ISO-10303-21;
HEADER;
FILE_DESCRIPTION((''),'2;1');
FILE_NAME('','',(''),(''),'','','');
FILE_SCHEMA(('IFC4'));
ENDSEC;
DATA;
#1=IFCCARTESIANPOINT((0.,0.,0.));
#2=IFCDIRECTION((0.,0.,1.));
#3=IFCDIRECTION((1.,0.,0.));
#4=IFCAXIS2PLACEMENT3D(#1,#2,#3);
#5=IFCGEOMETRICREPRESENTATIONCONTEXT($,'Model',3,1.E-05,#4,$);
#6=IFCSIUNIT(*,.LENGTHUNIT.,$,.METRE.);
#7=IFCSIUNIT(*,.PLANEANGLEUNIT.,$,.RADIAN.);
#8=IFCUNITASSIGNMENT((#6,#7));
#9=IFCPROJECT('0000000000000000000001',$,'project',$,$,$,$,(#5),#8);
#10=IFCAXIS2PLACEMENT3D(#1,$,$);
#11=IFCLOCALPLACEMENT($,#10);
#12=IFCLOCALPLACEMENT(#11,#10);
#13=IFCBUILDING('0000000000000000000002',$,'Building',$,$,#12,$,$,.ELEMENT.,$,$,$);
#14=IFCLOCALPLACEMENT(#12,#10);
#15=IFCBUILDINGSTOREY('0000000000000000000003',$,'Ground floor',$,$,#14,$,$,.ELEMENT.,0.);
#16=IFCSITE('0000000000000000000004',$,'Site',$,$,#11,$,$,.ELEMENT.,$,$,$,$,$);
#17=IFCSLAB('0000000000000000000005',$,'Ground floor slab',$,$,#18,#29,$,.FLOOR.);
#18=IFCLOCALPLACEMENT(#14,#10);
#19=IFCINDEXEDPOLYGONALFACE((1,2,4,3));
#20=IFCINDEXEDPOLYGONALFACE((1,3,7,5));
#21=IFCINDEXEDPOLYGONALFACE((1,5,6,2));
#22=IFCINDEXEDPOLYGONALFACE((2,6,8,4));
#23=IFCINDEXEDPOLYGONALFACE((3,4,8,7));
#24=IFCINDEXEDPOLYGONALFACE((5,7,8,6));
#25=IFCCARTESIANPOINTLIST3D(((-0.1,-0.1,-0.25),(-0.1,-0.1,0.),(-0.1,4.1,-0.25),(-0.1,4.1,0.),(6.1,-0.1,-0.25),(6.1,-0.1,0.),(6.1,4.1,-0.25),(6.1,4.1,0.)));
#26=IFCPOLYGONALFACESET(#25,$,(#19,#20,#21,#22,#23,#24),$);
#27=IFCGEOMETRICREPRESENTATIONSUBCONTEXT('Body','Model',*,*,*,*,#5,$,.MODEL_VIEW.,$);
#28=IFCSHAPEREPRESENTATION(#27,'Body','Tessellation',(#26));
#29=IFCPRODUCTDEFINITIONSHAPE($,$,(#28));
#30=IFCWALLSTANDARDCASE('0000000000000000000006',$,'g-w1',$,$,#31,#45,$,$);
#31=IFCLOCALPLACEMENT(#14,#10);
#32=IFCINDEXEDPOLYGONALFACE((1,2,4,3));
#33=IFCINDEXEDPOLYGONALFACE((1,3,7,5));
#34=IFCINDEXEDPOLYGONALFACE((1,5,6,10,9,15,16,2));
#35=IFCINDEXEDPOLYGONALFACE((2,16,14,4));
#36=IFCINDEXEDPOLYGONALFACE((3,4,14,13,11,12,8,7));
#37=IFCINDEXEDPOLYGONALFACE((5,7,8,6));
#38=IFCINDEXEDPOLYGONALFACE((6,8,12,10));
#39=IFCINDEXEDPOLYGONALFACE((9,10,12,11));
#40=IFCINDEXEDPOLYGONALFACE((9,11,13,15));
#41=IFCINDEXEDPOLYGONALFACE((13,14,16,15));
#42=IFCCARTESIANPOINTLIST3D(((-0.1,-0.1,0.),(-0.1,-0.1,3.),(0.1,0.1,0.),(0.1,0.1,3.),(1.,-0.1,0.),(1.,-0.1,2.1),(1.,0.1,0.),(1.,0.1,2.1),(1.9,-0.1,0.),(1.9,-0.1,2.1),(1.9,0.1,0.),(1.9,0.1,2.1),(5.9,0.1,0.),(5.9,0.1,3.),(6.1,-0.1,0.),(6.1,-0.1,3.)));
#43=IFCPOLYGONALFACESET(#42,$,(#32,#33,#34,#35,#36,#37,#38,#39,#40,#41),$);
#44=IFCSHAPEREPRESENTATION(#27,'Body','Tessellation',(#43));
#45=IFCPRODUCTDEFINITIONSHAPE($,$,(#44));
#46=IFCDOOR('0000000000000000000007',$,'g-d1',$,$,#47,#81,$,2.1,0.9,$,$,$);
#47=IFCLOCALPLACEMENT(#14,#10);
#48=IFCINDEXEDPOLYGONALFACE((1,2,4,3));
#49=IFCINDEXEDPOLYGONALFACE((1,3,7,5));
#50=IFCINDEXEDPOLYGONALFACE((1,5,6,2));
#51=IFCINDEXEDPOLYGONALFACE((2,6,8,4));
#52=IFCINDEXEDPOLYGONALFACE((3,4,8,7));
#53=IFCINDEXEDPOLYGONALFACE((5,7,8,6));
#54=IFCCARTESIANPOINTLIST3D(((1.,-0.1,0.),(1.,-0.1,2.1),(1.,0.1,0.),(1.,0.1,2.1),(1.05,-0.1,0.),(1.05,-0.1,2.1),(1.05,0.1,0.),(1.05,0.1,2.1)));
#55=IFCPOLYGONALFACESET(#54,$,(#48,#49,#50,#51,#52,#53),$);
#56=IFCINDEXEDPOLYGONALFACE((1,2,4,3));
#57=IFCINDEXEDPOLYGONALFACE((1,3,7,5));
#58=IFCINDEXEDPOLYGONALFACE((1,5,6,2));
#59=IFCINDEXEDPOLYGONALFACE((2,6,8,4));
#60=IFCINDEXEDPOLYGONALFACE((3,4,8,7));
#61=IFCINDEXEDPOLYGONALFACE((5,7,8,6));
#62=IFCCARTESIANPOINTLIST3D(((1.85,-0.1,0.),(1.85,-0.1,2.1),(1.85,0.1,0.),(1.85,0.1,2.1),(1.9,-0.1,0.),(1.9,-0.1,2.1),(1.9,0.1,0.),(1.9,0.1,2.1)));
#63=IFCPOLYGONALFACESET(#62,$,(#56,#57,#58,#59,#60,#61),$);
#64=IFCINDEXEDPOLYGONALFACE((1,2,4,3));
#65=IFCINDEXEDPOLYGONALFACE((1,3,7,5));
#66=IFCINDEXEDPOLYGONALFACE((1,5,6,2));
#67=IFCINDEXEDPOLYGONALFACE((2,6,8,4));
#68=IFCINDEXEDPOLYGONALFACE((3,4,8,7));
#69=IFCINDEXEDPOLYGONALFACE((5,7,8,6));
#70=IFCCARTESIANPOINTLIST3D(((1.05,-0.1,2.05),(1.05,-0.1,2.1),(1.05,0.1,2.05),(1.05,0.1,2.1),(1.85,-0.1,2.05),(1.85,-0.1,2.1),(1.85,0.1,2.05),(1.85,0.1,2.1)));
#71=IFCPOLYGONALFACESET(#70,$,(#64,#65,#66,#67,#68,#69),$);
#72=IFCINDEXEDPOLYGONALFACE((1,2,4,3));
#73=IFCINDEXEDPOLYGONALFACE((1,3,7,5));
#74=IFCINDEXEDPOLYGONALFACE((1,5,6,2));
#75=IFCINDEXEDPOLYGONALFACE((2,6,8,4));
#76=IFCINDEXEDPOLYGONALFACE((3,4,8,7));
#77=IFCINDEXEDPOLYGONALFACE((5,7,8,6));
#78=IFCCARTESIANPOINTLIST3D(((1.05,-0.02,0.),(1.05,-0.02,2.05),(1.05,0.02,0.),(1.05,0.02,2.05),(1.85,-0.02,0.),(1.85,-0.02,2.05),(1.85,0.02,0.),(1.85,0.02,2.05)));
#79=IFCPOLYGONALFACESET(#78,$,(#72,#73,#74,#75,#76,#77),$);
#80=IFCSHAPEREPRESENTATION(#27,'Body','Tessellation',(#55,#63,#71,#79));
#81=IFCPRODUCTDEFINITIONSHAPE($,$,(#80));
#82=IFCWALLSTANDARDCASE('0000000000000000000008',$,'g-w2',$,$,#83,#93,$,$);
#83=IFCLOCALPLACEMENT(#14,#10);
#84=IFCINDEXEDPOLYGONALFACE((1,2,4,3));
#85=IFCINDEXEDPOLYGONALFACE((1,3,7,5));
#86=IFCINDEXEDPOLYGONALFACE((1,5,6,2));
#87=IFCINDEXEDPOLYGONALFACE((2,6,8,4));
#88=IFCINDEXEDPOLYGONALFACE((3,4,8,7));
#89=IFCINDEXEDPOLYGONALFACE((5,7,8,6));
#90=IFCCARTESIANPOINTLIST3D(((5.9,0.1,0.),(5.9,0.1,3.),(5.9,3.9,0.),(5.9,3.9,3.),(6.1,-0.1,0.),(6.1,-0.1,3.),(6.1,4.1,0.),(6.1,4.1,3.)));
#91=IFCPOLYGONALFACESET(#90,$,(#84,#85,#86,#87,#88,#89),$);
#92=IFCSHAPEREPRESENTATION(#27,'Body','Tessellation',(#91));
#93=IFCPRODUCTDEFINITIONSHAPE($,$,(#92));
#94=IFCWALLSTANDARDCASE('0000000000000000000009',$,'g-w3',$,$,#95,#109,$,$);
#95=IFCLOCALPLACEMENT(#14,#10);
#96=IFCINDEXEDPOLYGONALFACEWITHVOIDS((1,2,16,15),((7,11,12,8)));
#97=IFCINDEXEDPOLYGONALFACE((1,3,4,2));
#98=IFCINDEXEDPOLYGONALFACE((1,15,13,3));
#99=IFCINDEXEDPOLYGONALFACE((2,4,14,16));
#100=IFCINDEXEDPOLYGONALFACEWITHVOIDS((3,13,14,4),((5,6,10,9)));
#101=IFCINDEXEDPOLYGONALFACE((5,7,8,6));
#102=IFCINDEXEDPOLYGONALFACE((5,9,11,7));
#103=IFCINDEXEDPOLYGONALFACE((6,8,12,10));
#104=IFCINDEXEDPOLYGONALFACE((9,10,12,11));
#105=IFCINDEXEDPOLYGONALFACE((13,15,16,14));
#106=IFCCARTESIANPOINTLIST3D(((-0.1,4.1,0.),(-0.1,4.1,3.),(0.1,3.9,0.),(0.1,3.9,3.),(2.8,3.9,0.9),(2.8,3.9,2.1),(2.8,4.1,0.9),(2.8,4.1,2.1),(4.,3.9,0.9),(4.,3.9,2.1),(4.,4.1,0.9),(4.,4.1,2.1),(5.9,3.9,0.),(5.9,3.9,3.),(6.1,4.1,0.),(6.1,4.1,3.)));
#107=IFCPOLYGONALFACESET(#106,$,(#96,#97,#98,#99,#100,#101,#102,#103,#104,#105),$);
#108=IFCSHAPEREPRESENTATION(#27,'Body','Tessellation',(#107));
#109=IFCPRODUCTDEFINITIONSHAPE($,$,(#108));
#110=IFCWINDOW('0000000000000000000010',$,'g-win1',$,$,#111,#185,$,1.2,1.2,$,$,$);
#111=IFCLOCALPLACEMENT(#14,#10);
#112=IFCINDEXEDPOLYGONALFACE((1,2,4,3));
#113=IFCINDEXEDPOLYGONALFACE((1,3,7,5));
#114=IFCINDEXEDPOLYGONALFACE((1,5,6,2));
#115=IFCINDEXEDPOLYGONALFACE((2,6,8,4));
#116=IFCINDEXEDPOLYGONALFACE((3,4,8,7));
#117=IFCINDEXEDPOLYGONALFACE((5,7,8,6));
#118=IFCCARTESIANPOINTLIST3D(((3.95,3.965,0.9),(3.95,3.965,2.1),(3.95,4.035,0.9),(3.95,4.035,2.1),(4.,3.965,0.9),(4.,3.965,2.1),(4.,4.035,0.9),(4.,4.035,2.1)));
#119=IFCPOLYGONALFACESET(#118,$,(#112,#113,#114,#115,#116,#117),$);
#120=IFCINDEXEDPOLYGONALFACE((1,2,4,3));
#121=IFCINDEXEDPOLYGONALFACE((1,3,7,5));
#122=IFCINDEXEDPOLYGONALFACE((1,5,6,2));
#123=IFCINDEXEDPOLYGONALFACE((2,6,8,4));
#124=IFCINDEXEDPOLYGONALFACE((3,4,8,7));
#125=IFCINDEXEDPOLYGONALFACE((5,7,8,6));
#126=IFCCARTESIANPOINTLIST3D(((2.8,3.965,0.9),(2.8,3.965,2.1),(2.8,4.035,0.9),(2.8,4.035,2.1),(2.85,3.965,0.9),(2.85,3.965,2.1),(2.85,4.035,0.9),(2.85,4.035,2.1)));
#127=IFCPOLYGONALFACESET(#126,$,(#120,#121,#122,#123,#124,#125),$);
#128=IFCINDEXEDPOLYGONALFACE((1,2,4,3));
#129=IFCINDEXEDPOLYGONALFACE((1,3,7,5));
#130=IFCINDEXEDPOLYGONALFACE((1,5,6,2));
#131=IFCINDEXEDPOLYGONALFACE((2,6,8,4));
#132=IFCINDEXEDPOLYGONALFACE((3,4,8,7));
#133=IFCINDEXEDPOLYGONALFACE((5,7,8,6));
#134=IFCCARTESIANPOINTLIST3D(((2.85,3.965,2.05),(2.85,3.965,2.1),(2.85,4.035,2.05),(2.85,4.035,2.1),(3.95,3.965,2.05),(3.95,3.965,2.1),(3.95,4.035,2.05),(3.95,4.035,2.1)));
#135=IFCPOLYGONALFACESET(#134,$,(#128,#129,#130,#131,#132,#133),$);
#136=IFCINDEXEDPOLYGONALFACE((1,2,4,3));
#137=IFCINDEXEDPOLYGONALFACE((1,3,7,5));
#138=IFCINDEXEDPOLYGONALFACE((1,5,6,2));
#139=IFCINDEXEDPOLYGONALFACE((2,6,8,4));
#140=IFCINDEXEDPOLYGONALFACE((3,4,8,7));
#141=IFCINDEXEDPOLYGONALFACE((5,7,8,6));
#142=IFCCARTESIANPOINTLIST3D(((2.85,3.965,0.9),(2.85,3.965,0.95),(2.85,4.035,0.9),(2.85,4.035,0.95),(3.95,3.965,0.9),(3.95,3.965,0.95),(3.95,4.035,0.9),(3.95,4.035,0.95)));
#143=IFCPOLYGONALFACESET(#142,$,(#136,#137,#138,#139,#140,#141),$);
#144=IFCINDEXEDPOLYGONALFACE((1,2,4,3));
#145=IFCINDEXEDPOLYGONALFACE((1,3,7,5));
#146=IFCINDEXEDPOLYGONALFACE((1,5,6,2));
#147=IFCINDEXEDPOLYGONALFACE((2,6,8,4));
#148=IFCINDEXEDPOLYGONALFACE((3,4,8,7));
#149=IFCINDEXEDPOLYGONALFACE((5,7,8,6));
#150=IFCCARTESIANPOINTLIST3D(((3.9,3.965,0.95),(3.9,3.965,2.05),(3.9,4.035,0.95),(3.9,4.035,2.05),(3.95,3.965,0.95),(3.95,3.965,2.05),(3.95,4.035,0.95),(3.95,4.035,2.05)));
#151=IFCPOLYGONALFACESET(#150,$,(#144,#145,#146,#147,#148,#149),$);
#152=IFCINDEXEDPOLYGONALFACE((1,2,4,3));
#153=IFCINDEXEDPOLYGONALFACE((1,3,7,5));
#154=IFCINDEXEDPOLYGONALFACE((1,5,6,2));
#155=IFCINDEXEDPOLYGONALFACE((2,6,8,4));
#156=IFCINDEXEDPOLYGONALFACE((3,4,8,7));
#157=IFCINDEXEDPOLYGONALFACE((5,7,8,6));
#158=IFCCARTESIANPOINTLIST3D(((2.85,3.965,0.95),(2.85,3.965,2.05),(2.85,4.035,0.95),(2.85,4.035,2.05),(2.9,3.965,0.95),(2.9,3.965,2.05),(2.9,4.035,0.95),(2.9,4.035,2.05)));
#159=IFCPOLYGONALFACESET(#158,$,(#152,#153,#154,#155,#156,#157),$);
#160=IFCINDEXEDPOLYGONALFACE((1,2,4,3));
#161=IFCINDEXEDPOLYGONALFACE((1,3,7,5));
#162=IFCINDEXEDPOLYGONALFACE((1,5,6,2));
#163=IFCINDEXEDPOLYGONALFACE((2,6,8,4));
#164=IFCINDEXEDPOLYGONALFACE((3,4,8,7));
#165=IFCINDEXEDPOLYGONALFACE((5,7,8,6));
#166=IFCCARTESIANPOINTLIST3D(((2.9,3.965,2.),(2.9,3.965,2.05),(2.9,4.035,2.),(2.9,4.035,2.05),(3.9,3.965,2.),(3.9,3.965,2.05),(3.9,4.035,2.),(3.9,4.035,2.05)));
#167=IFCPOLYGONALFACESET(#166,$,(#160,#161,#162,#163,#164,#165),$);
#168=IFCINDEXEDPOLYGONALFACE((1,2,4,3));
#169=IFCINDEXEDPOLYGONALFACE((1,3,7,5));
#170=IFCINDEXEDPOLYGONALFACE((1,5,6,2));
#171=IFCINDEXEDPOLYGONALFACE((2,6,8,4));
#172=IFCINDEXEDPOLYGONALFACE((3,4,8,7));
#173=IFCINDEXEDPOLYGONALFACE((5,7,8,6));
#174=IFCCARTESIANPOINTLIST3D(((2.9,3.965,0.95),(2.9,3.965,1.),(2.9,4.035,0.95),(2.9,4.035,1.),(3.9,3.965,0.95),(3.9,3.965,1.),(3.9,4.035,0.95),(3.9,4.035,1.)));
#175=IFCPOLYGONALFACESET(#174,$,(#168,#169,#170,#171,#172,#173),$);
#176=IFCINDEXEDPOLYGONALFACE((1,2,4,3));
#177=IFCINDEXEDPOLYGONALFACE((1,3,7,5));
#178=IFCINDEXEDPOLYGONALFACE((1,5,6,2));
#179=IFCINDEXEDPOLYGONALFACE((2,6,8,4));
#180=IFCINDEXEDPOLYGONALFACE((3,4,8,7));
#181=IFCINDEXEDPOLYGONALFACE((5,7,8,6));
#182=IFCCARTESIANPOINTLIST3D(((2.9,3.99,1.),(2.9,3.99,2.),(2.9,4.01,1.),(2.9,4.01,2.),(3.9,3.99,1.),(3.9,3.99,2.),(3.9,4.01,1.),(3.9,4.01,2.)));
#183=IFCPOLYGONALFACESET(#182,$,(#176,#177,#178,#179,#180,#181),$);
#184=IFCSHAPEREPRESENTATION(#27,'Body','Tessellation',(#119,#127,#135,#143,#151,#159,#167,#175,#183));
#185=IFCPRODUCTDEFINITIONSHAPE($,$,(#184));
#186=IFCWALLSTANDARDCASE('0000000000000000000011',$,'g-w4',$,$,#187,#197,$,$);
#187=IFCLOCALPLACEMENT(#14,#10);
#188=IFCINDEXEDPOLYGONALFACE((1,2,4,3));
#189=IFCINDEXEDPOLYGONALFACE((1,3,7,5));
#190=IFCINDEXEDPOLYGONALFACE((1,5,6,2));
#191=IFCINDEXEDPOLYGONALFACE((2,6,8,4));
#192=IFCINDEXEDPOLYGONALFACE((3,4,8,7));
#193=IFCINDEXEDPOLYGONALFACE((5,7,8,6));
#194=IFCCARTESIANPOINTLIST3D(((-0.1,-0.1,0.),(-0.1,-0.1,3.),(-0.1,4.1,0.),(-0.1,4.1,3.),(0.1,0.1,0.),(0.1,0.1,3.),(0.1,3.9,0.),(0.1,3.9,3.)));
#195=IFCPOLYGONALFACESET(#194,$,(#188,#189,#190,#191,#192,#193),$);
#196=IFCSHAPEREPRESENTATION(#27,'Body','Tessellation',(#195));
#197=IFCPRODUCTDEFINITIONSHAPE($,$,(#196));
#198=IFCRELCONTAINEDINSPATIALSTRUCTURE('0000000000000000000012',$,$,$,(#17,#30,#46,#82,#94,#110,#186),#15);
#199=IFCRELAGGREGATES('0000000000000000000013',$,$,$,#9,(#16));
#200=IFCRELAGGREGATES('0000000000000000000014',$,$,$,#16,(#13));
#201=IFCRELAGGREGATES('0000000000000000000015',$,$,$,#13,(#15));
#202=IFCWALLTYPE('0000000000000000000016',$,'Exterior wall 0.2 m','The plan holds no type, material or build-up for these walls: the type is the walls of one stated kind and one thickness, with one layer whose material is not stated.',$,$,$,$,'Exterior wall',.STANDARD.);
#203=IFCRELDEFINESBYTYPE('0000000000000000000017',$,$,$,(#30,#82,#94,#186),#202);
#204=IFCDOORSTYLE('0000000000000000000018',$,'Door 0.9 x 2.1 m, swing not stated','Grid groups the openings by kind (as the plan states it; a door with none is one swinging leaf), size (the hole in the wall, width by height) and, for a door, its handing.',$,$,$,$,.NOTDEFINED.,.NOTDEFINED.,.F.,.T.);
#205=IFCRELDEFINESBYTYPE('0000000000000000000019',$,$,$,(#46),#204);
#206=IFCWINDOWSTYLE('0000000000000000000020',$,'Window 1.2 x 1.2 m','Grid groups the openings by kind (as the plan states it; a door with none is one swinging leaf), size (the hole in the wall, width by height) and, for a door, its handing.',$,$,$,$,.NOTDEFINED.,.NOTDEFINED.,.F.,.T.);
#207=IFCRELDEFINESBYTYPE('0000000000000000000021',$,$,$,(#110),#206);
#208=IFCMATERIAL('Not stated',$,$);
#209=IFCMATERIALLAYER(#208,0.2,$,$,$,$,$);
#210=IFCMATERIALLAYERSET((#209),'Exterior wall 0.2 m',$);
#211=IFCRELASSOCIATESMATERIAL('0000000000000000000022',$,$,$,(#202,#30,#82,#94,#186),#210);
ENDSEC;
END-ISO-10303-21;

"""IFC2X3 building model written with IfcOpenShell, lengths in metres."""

from ifc_helpers import new_model, si_unit, frame, frame_2d, origin, origin_with_axes, place, context, subcontext, project, spatial, polyline, rectangle, outline, extrude, material, layer, layer_set, layer_usage, type_object, element, fill, save


model = new_model("IFC2X3")

# Units and contexts
model_context = context("Model", 3, precision=1e-05, world=origin_with_axes())
body_context = subcontext(model_context, "Body", "Model", "MODEL_VIEW")
ifc_project = project(units=[si_unit("LENGTHUNIT", "METRE"), si_unit("PLANEANGLEUNIT", "RADIAN")], contexts=[model_context])

# Site, building, storey
site_placement = place(None, origin())
site = spatial("IfcSite", under=ifc_project, at=site_placement, Name="Site", CompositionType="ELEMENT")
building_placement = place(site_placement, origin())
building = spatial("IfcBuilding", under=site, at=building_placement, Name="Building", CompositionType="ELEMENT")
storey_placement = place(building_placement, origin())
storey = spatial("IfcBuildingStorey", under=building, at=storey_placement, Name="Ground floor", CompositionType="ELEMENT", Elevation=0.0)

# Slab
slab_placement = place(storey_placement, frame((0.0, 0.0, -0.25)))
element("IfcSlab", 1, at=slab_placement, inside=storey, Name="Ground floor slab", PredefinedType="FLOOR", context=body_context, shape_type="SweptSolid", body=[
    extrude(outline(polyline([(-0.1, -0.1), (6.1, -0.1), (6.1, 4.1), (-0.1, 4.1), (-0.1, -0.1)])), origin(), (0.0, 0.0, 1.0), 0.25),
])

# Wall, opening, door
ifc_material = material(Name="Not stated")
ifc_layer = layer(ifc_material, 0.2)
ifc_layer_set = layer_set([ifc_layer], Name="Exterior wall 0.2 m")
ifc_layer_usage = layer_usage(ifc_layer_set, "AXIS2", "POSITIVE", -0.1)
wall_type = type_object("IfcWallType", Name="Exterior wall 0.2 m", Description="The plan holds no type, material or build-up for these walls: the type is the walls of one stated kind and one thickness, with one layer whose material is not stated.", ElementType="Exterior wall", PredefinedType="STANDARD", material=ifc_layer_set)
wall_1_placement = place(storey_placement, origin_with_axes())
wall_1 = element("IfcWallStandardCase", 2, at=wall_1_placement, inside=storey, type_object=wall_type, material=ifc_layer_usage, Name="g-w1", context=body_context, shape_type="SweptSolid", body=[
    extrude(outline(polyline([(-0.1, -0.1), (6.1, -0.1), (5.9, 0.1), (0.1, 0.1), (-0.1, -0.1)])), origin(), (0.0, 0.0, 1.0), 3.0),
])
opening_1_placement = place(wall_1_placement, frame((1.0, 0.0, 0.0)))
opening_1 = element("IfcOpeningElement", 3, at=opening_1_placement, cuts=wall_1, context=body_context, shape_type="SweptSolid", body=[
    extrude(rectangle(XDim=0.9, YDim=0.22, at=frame_2d((0.45, 0.0), x_axis=(1.0, 0.0))), origin(), (0.0, 0.0, 1.0), 2.1),
])
door_style = type_object("IfcDoorStyle", Name="Door 0.9 x 2.1 m, swing not stated", Description="Grid groups the openings by kind (as the plan states it; a door with none is one swinging leaf), size (the hole in the wall, width by height) and, for a door, its handing.", ConstructionType="NOTDEFINED", OperationType="NOTDEFINED", ParameterTakesPrecedence=False, Sizeable=True)
door_placement = place(opening_1_placement, origin())
door = element("IfcDoor", 4, at=door_placement, inside=storey, type_object=door_style, Name="g-d1", OverallHeight=2.1, OverallWidth=0.9, context=body_context, shape_type="SweptSolid", body=[
    extrude(rectangle(XDim=0.05, YDim=0.2, at=frame_2d((0.025, 0.0), x_axis=(1.0, 0.0))), origin(), (0.0, 0.0, 1.0), 2.1),
    extrude(rectangle(XDim=0.05, YDim=0.2, at=frame_2d((0.875, 0.0), x_axis=(1.0, 0.0))), origin(), (0.0, 0.0, 1.0), 2.1),
    extrude(rectangle(XDim=0.8, YDim=0.2, at=frame_2d((0.45, 0.0), x_axis=(1.0, 0.0))), frame((0.0, 0.0, 2.05)), (0.0, 0.0, 1.0), 0.05),
    extrude(rectangle(XDim=0.8, YDim=0.04, at=frame_2d((0.45, 0.0), x_axis=(1.0, 0.0))), origin(), (0.0, 0.0, 1.0), 2.05),
])
fill(opening_1, door)

# Wall
wall_2_placement = place(storey_placement, frame((6.0, 0.0, 0.0), z_axis=(0.0, 0.0, 1.0), x_axis=(0.0, 1.0, 0.0)))
element("IfcWallStandardCase", 5, at=wall_2_placement, inside=storey, type_object=wall_type, material=ifc_layer_usage, Name="g-w2", context=body_context, shape_type="SweptSolid", body=[
    extrude(outline(polyline([(-0.1, -0.1), (4.1, -0.1), (3.9, 0.1), (0.1, 0.1), (-0.1, -0.1)])), origin(), (0.0, 0.0, 1.0), 3.0),
])

# Wall, opening, window
wall_3_placement = place(storey_placement, frame((6.0, 4.0, 0.0), z_axis=(0.0, 0.0, 1.0), x_axis=(-1.0, 0.0, 0.0)))
wall_3 = element("IfcWallStandardCase", 6, at=wall_3_placement, inside=storey, type_object=wall_type, material=ifc_layer_usage, Name="g-w3", context=body_context, shape_type="SweptSolid", body=[
    extrude(outline(polyline([(-0.1, -0.1), (6.1, -0.1), (5.9, 0.1), (0.1, 0.1), (-0.1, -0.1)])), origin(), (0.0, 0.0, 1.0), 3.0),
])
opening_2_placement = place(wall_3_placement, frame((2.0, 0.0, 0.9)))
opening_2 = element("IfcOpeningElement", 7, at=opening_2_placement, cuts=wall_3, context=body_context, shape_type="SweptSolid", body=[
    extrude(rectangle(XDim=1.2, YDim=0.22, at=frame_2d((0.6, 0.0), x_axis=(1.0, 0.0))), origin(), (0.0, 0.0, 1.0), 1.2),
])
window_style = type_object("IfcWindowStyle", Name="Window 1.2 x 1.2 m", Description="Grid groups the openings by kind (as the plan states it; a door with none is one swinging leaf), size (the hole in the wall, width by height) and, for a door, its handing.", ConstructionType="NOTDEFINED", OperationType="NOTDEFINED", ParameterTakesPrecedence=False, Sizeable=True)
window_placement = place(opening_2_placement, origin())
window = element("IfcWindow", 8, at=window_placement, inside=storey, type_object=window_style, Name="g-win1", OverallHeight=1.2, OverallWidth=1.2, context=body_context, shape_type="SweptSolid", body=[
    extrude(rectangle(XDim=0.05, YDim=0.07, at=frame_2d((0.025, 0.0), x_axis=(1.0, 0.0))), origin(), (0.0, 0.0, 1.0), 1.2),
    extrude(rectangle(XDim=0.05, YDim=0.07, at=frame_2d((1.175, 0.0), x_axis=(1.0, 0.0))), origin(), (0.0, 0.0, 1.0), 1.2),
    extrude(rectangle(XDim=1.1, YDim=0.07, at=frame_2d((0.6, 0.0), x_axis=(1.0, 0.0))), frame((0.0, 0.0, 1.15)), (0.0, 0.0, 1.0), 0.05),
    extrude(rectangle(XDim=1.1, YDim=0.07, at=frame_2d((0.6, 0.0), x_axis=(1.0, 0.0))), origin(), (0.0, 0.0, 1.0), 0.05),
    extrude(rectangle(XDim=0.05, YDim=0.07, at=frame_2d((0.075, 0.0), x_axis=(1.0, 0.0))), frame((0.0, 0.0, 0.05)), (0.0, 0.0, 1.0), 1.1),
    extrude(rectangle(XDim=0.05, YDim=0.07, at=frame_2d((1.125, 0.0), x_axis=(1.0, 0.0))), frame((0.0, 0.0, 0.05)), (0.0, 0.0, 1.0), 1.1),
    extrude(rectangle(XDim=1.0, YDim=0.07, at=frame_2d((0.6, 0.0), x_axis=(1.0, 0.0))), frame((0.0, 0.0, 1.1)), (0.0, 0.0, 1.0), 0.05),
    extrude(rectangle(XDim=1.0, YDim=0.07, at=frame_2d((0.6, 0.0), x_axis=(1.0, 0.0))), frame((0.0, 0.0, 0.05)), (0.0, 0.0, 1.0), 0.05),
    extrude(rectangle(XDim=1.0, YDim=0.02, at=frame_2d((0.6, 0.0), x_axis=(1.0, 0.0))), frame((0.0, 0.0, 0.1)), (0.0, 0.0, 1.0), 1.0),
])
fill(opening_2, window)

# Wall
wall_4_placement = place(storey_placement, frame((0.0, 4.0, 0.0), z_axis=(0.0, 0.0, 1.0), x_axis=(0.0, -1.0, 0.0)))
element("IfcWallStandardCase", 9, at=wall_4_placement, inside=storey, type_object=wall_type, material=ifc_layer_usage, Name="g-w4", context=body_context, shape_type="SweptSolid", body=[
    extrude(outline(polyline([(-0.1, -0.1), (4.1, -0.1), (3.9, 0.1), (0.1, 0.1), (-0.1, -0.1)])), origin(), (0.0, 0.0, 1.0), 3.0),
])

save(model, "model.ifc")
